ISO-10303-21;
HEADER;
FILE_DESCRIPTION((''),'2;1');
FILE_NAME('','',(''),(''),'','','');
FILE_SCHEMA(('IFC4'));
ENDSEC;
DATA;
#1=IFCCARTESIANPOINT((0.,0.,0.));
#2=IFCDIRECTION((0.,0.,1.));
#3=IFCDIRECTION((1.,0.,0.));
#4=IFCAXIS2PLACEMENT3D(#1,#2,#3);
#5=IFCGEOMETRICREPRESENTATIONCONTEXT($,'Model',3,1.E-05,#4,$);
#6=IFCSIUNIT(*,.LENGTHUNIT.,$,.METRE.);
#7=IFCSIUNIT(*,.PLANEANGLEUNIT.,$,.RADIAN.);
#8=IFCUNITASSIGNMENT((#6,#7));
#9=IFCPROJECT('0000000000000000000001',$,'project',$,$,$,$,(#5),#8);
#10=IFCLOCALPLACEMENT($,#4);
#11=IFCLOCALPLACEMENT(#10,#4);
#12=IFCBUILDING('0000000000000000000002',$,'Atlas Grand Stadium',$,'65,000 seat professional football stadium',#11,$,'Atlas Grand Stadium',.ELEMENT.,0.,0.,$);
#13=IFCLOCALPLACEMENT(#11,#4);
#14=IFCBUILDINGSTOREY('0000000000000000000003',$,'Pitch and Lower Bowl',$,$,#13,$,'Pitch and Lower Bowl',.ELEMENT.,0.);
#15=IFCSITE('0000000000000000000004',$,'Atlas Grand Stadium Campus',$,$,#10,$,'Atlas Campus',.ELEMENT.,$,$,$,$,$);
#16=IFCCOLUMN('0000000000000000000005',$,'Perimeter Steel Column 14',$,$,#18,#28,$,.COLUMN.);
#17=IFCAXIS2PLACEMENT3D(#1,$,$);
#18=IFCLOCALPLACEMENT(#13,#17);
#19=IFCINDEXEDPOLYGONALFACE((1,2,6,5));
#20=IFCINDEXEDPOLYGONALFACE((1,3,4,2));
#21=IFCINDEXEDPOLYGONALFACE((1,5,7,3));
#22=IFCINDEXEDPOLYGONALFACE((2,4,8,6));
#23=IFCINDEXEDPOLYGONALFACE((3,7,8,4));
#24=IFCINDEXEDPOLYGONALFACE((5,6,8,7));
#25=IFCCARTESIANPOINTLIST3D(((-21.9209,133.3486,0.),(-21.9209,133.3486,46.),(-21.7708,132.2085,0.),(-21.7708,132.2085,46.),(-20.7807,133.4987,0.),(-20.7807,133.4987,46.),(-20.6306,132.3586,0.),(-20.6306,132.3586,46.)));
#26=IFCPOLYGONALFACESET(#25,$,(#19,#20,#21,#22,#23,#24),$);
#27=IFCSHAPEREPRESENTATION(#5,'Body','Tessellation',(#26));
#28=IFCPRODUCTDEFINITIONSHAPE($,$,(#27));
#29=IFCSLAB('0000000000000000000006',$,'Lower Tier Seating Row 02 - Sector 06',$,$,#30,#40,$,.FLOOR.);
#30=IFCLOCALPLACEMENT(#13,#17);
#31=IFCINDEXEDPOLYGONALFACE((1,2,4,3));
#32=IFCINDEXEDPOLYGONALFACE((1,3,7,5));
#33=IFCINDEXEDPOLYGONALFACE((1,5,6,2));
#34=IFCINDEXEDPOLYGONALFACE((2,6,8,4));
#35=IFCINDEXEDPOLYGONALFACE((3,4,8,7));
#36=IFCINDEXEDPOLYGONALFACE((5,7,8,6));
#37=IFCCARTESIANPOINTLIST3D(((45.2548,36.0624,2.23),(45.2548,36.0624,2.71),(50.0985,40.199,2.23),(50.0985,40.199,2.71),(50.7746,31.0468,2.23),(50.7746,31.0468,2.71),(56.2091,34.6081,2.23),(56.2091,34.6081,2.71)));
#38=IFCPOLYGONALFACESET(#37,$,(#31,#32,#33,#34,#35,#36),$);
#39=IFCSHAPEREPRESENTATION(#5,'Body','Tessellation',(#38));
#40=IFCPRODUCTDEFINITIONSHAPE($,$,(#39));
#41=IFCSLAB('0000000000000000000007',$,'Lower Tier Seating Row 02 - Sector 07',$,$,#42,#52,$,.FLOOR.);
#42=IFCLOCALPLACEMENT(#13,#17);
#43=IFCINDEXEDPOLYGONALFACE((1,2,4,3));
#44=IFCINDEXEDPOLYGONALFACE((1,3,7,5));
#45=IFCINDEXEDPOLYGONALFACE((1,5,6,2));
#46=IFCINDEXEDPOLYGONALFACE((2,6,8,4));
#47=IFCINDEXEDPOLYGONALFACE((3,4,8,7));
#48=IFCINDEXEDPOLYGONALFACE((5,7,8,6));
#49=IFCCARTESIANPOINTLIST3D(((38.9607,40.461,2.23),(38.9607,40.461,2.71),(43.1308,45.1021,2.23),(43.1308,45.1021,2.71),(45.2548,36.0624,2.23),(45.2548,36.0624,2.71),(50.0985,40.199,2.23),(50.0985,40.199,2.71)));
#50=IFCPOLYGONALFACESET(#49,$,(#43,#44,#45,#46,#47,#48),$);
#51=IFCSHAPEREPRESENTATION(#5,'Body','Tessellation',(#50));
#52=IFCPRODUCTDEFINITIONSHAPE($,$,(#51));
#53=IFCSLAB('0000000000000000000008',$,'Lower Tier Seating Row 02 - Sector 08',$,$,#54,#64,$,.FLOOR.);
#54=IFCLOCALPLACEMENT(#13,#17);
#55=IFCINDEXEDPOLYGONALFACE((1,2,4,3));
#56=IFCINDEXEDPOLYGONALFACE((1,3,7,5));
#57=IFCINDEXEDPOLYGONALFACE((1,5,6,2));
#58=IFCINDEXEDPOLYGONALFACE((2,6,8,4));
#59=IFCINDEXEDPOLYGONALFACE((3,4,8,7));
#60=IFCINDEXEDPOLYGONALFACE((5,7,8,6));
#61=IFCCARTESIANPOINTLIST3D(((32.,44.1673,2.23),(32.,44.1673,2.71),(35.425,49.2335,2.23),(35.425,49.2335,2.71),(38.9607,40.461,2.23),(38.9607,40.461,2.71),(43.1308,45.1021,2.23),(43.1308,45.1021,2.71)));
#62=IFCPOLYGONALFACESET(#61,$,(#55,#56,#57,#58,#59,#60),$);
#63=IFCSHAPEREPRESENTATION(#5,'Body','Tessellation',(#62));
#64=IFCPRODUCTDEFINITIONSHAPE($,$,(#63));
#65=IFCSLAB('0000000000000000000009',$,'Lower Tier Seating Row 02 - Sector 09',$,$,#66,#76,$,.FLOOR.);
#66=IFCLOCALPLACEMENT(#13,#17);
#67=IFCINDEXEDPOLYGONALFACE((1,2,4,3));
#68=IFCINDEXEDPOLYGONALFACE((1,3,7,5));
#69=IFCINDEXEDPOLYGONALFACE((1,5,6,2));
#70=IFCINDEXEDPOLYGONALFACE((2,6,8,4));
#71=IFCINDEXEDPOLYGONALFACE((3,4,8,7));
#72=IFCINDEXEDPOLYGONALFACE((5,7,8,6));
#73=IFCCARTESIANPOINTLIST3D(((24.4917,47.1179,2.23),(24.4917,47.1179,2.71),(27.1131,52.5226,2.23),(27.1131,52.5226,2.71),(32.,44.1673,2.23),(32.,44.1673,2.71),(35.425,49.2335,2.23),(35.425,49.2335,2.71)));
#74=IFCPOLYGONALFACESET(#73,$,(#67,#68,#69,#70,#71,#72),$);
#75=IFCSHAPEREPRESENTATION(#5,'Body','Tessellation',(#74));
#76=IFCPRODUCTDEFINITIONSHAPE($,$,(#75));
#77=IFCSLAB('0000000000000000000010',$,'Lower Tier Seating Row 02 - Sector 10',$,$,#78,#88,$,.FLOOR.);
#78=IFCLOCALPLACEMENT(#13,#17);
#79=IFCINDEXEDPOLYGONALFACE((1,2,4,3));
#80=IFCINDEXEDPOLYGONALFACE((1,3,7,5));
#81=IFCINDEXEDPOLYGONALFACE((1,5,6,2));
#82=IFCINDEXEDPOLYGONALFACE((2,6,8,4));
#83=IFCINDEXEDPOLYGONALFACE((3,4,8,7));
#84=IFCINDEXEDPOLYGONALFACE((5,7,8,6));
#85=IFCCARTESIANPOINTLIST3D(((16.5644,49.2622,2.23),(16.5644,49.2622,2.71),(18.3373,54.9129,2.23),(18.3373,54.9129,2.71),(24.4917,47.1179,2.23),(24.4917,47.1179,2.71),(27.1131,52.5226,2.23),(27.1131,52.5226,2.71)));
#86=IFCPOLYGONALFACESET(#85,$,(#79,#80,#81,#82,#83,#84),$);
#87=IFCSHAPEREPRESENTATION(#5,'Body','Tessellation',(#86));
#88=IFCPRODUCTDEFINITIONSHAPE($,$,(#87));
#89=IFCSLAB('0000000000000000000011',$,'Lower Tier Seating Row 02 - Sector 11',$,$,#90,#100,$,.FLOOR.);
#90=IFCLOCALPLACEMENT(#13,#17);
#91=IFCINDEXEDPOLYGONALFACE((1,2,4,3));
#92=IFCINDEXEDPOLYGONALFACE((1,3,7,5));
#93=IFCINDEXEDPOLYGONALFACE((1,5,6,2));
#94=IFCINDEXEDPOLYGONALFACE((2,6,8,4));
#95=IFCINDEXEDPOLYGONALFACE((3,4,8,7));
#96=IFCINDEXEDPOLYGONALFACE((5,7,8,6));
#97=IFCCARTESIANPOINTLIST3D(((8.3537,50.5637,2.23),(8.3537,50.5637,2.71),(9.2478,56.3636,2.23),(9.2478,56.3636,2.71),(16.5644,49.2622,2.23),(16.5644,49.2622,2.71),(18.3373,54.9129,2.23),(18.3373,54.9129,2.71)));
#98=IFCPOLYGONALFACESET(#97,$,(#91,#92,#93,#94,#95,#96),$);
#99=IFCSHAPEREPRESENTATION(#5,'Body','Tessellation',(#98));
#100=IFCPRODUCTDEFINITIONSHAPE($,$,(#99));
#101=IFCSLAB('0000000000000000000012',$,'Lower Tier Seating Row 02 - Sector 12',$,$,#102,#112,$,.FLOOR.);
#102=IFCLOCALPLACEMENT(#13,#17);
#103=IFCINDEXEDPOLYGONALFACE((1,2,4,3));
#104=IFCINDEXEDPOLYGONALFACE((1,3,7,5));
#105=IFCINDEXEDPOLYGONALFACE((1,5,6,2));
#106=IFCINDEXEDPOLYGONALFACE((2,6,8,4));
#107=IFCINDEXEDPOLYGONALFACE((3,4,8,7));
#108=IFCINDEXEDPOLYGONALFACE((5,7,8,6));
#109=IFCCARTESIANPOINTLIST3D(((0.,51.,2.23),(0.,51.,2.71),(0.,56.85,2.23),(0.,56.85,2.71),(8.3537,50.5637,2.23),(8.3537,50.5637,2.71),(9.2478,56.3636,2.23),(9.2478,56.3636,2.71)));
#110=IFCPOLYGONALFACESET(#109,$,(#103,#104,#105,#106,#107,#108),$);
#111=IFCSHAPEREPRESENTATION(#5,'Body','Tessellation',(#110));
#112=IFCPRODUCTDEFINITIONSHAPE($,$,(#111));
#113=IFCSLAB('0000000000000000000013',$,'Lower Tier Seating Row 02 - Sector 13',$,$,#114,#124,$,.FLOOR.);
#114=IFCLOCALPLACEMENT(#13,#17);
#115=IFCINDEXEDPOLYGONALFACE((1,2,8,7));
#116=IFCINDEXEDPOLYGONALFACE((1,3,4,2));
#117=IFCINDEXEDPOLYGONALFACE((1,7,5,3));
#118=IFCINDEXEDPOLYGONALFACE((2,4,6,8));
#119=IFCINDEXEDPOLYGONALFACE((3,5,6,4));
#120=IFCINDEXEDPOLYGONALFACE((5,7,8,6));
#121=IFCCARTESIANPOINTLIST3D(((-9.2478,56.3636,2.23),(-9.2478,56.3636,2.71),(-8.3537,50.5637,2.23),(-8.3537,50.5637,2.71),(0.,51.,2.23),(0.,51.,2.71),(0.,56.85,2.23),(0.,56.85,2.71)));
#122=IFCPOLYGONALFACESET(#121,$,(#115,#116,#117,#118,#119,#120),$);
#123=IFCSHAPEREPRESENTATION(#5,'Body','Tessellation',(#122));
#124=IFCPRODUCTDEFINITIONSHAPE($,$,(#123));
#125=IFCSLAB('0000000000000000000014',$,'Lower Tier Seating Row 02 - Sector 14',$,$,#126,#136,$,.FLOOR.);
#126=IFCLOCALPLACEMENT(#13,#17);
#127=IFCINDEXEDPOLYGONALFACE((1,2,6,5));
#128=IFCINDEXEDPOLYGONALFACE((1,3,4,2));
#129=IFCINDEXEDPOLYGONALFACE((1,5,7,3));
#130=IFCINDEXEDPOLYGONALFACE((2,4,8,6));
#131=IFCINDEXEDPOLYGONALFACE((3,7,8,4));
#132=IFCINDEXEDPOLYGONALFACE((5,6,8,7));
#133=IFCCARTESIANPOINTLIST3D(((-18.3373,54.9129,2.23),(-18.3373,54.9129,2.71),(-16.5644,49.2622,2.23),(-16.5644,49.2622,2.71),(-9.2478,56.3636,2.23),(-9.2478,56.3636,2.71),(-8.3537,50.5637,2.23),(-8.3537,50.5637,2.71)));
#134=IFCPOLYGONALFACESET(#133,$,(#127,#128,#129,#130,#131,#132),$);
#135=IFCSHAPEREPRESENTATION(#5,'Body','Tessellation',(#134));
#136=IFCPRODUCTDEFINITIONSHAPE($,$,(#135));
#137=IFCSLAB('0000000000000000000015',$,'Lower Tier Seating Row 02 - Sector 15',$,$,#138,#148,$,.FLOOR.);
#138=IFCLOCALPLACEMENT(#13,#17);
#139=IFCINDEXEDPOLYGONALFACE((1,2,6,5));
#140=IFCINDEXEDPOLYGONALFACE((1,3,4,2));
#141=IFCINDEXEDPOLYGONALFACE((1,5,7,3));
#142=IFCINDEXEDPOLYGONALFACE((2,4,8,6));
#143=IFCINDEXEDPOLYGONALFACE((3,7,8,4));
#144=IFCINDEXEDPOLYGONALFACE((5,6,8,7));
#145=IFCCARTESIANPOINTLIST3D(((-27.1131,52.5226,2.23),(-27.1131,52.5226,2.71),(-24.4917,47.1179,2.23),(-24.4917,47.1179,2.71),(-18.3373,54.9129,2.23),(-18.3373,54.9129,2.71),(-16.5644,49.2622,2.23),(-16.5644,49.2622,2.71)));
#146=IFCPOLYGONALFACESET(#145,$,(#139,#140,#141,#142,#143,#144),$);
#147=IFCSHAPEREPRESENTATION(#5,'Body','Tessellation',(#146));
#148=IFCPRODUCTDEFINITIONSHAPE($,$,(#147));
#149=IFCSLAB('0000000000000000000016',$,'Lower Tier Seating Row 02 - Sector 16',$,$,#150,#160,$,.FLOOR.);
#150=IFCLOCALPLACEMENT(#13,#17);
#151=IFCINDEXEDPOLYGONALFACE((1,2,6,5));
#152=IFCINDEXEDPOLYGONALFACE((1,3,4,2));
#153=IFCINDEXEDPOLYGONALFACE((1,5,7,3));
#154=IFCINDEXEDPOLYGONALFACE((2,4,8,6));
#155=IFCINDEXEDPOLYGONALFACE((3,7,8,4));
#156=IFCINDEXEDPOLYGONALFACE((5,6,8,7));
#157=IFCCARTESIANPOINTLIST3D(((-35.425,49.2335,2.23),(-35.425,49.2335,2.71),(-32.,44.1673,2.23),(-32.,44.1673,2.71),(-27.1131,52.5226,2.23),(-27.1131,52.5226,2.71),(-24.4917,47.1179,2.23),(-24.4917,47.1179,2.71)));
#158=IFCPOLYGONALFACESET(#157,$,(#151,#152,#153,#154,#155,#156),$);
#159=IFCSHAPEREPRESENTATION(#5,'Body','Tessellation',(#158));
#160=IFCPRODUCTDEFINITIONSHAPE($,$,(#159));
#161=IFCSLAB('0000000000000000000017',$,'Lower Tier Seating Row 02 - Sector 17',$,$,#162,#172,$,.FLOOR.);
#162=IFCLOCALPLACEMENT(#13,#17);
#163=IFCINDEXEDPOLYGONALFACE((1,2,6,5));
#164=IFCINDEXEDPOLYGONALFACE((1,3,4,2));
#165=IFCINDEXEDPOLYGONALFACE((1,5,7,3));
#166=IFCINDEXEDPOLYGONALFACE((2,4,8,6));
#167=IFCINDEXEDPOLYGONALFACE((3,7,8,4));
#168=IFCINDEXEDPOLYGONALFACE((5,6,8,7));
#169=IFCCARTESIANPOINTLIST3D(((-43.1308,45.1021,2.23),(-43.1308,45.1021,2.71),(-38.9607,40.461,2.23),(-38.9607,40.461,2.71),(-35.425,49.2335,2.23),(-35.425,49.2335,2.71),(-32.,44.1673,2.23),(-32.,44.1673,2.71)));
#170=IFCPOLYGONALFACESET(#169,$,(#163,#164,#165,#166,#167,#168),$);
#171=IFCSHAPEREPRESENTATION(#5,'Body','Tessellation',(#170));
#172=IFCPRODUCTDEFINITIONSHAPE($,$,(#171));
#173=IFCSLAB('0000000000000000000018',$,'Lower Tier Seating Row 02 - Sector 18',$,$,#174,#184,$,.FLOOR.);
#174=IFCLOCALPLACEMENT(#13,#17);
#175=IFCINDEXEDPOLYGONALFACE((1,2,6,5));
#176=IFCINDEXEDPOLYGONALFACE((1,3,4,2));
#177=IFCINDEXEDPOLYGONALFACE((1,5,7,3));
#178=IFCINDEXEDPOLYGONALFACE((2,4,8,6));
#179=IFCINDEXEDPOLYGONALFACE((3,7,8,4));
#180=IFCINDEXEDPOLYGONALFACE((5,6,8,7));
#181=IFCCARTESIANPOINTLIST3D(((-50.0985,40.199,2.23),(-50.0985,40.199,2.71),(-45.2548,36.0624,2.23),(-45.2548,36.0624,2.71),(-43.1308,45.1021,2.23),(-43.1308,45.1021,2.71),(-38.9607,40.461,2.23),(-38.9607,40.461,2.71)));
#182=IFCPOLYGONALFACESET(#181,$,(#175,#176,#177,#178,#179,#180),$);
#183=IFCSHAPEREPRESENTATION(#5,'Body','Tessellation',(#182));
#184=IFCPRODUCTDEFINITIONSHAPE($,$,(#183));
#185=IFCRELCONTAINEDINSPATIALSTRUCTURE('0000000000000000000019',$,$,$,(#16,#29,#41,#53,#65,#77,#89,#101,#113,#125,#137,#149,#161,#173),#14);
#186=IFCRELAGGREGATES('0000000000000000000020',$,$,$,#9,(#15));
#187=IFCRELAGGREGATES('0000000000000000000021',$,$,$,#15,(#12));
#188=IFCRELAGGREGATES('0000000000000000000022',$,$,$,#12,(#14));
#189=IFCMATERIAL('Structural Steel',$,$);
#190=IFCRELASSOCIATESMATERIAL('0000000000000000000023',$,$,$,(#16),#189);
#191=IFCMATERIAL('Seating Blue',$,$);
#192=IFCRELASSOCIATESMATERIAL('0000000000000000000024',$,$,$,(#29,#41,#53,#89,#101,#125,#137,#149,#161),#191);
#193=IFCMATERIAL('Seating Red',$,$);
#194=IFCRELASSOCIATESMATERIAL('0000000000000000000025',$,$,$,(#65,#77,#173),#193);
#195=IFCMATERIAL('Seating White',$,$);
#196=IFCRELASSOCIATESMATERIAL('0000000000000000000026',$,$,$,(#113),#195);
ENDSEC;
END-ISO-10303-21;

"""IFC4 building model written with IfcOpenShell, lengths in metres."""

from ifc_helpers import new_model, si_unit, frame, origin_with_axes, origin_2d_with_axis, place, context, project, spatial, polyline, rectangle, outline, extrude, material, element, save


model = new_model("IFC4")

# Units and contexts
model_context = context("Model", 3, precision=1e-05, world=origin_with_axes())
ifc_project = project(units=[si_unit("LENGTHUNIT", "METRE"), si_unit("PLANEANGLEUNIT", "RADIAN")], contexts=[model_context])

# Site, building, storey
site_placement = place(None, origin_with_axes())
site = spatial("IfcSite", under=ifc_project, at=site_placement, Name="Atlas Grand Stadium Campus", LongName="Atlas Campus", CompositionType="ELEMENT")
building_placement = place(site_placement, origin_with_axes())
building = spatial("IfcBuilding", under=site, at=building_placement, Name="Atlas Grand Stadium", ObjectType="65,000 seat professional football stadium", LongName="Atlas Grand Stadium", CompositionType="ELEMENT", ElevationOfRefHeight=0.0, ElevationOfTerrain=0.0)
storey_placement = place(building_placement, origin_with_axes())
storey = spatial("IfcBuildingStorey", under=building, at=storey_placement, Name="Pitch and Lower Bowl", LongName="Pitch and Lower Bowl", CompositionType="ELEMENT", Elevation=0.0)

# Column
ifc_material_1 = material(Name="Structural Steel")
column_placement = place(storey_placement, frame((-21.2758, 132.8536, 0.0), z_axis=(0.0, 0.0, 1.0), x_axis=(-0.99144, -0.13053, 0.0)))
element("IfcColumn", 1, at=column_placement, inside=storey, material=ifc_material_1, Name="Perimeter Steel Column 14", PredefinedType="COLUMN", context=model_context, shape_type="SweptSolid", body=[
    extrude(rectangle(XDim=1.15, YDim=1.15, at=origin_2d_with_axis()), origin_with_axes(), (0.0, 0.0, 1.0), 46.0),
])

# Slabs
ifc_material_2 = material(Name="Seating Blue")
slab_1_placement = place(storey_placement, frame((0.0, 0.0, 2.23), z_axis=(0.0, 0.0, 1.0), x_axis=(1.0, 0.0, 0.0)))
element("IfcSlab", 2, at=slab_1_placement, inside=storey, material=ifc_material_2, Name="Lower Tier Seating Row 02 - Sector 06", PredefinedType="FLOOR", context=model_context, shape_type="SweptSolid", body=[
    extrude(outline(polyline([(56.2091, 34.6081), (50.0985, 40.199), (45.2548, 36.0624), (50.7746, 31.0468), (56.2091, 34.6081)])), origin_with_axes(), (0.0, 0.0, 1.0), 0.48),
])
slab_2_placement = place(storey_placement, frame((0.0, 0.0, 2.23), z_axis=(0.0, 0.0, 1.0), x_axis=(1.0, 0.0, 0.0)))
element("IfcSlab", 3, at=slab_2_placement, inside=storey, material=ifc_material_2, Name="Lower Tier Seating Row 02 - Sector 07", PredefinedType="FLOOR", context=model_context, shape_type="SweptSolid", body=[
    extrude(outline(polyline([(50.0985, 40.199), (43.1307, 45.1021), (38.9607, 40.461), (45.2548, 36.0624), (50.0985, 40.199)])), origin_with_axes(), (0.0, 0.0, 1.0), 0.48),
])
slab_3_placement = place(storey_placement, frame((0.0, 0.0, 2.23), z_axis=(0.0, 0.0, 1.0), x_axis=(1.0, 0.0, 0.0)))
element("IfcSlab", 4, at=slab_3_placement, inside=storey, material=ifc_material_2, Name="Lower Tier Seating Row 02 - Sector 08", PredefinedType="FLOOR", context=model_context, shape_type="SweptSolid", body=[
    extrude(outline(polyline([(43.1307, 45.1021), (35.425, 49.2335), (32.0, 44.1673), (38.9607, 40.461), (43.1307, 45.1021)])), origin_with_axes(), (0.0, 0.0, 1.0), 0.48),
])
ifc_material_3 = material(Name="Seating Red")
slab_4_placement = place(storey_placement, frame((0.0, 0.0, 2.23), z_axis=(0.0, 0.0, 1.0), x_axis=(1.0, 0.0, 0.0)))
element("IfcSlab", 5, at=slab_4_placement, inside=storey, material=ifc_material_3, Name="Lower Tier Seating Row 02 - Sector 09", PredefinedType="FLOOR", context=model_context, shape_type="SweptSolid", body=[
    extrude(outline(polyline([(35.425, 49.2335), (27.1131, 52.5226), (24.4917, 47.1179), (32.0, 44.1673), (35.425, 49.2335)])), origin_with_axes(), (0.0, 0.0, 1.0), 0.48),
])
slab_5_placement = place(storey_placement, frame((0.0, 0.0, 2.23), z_axis=(0.0, 0.0, 1.0), x_axis=(1.0, 0.0, 0.0)))
element("IfcSlab", 6, at=slab_5_placement, inside=storey, material=ifc_material_3, Name="Lower Tier Seating Row 02 - Sector 10", PredefinedType="FLOOR", context=model_context, shape_type="SweptSolid", body=[
    extrude(outline(polyline([(27.1131, 52.5226), (18.3373, 54.9129), (16.5644, 49.2622), (24.4917, 47.1179), (27.1131, 52.5226)])), origin_with_axes(), (0.0, 0.0, 1.0), 0.48),
])
slab_6_placement = place(storey_placement, frame((0.0, 0.0, 2.23), z_axis=(0.0, 0.0, 1.0), x_axis=(1.0, 0.0, 0.0)))
element("IfcSlab", 7, at=slab_6_placement, inside=storey, material=ifc_material_2, Name="Lower Tier Seating Row 02 - Sector 11", PredefinedType="FLOOR", context=model_context, shape_type="SweptSolid", body=[
    extrude(outline(polyline([(18.3373, 54.9129), (9.2478, 56.3636), (8.3537, 50.5637), (16.5644, 49.2622), (18.3373, 54.9129)])), origin_with_axes(), (0.0, 0.0, 1.0), 0.48),
])
slab_7_placement = place(storey_placement, frame((0.0, 0.0, 2.23), z_axis=(0.0, 0.0, 1.0), x_axis=(1.0, 0.0, 0.0)))
element("IfcSlab", 8, at=slab_7_placement, inside=storey, material=ifc_material_2, Name="Lower Tier Seating Row 02 - Sector 12", PredefinedType="FLOOR", context=model_context, shape_type="SweptSolid", body=[
    extrude(outline(polyline([(9.2478, 56.3636), (0.0, 56.85), (0.0, 51.0), (8.3537, 50.5637), (9.2478, 56.3636)])), origin_with_axes(), (0.0, 0.0, 1.0), 0.48),
])
ifc_material_4 = material(Name="Seating White")
slab_8_placement = place(storey_placement, frame((0.0, 0.0, 2.23), z_axis=(0.0, 0.0, 1.0), x_axis=(1.0, 0.0, 0.0)))
element("IfcSlab", 9, at=slab_8_placement, inside=storey, material=ifc_material_4, Name="Lower Tier Seating Row 02 - Sector 13", PredefinedType="FLOOR", context=model_context, shape_type="SweptSolid", body=[
    extrude(outline(polyline([(0.0, 56.85), (-9.2478, 56.3636), (-8.3537, 50.5637), (0.0, 51.0), (0.0, 56.85)])), origin_with_axes(), (0.0, 0.0, 1.0), 0.48),
])
slab_9_placement = place(storey_placement, frame((0.0, 0.0, 2.23), z_axis=(0.0, 0.0, 1.0), x_axis=(1.0, 0.0, 0.0)))
element("IfcSlab", 10, at=slab_9_placement, inside=storey, material=ifc_material_2, Name="Lower Tier Seating Row 02 - Sector 14", PredefinedType="FLOOR", context=model_context, shape_type="SweptSolid", body=[
    extrude(outline(polyline([(-9.2478, 56.3636), (-18.3373, 54.9129), (-16.5644, 49.2622), (-8.3537, 50.5637), (-9.2478, 56.3636)])), origin_with_axes(), (0.0, 0.0, 1.0), 0.48),
])
slab_10_placement = place(storey_placement, frame((0.0, 0.0, 2.23), z_axis=(0.0, 0.0, 1.0), x_axis=(1.0, 0.0, 0.0)))
element("IfcSlab", 11, at=slab_10_placement, inside=storey, material=ifc_material_2, Name="Lower Tier Seating Row 02 - Sector 15", PredefinedType="FLOOR", context=model_context, shape_type="SweptSolid", body=[
    extrude(outline(polyline([(-18.3373, 54.9129), (-27.1131, 52.5226), (-24.4917, 47.1179), (-16.5644, 49.2622), (-18.3373, 54.9129)])), origin_with_axes(), (0.0, 0.0, 1.0), 0.48),
])
slab_11_placement = place(storey_placement, frame((0.0, 0.0, 2.23), z_axis=(0.0, 0.0, 1.0), x_axis=(1.0, 0.0, 0.0)))
element("IfcSlab", 12, at=slab_11_placement, inside=storey, material=ifc_material_2, Name="Lower Tier Seating Row 02 - Sector 16", PredefinedType="FLOOR", context=model_context, shape_type="SweptSolid", body=[
    extrude(outline(polyline([(-27.1131, 52.5226), (-35.425, 49.2335), (-32.0, 44.1673), (-24.4917, 47.1179), (-27.1131, 52.5226)])), origin_with_axes(), (0.0, 0.0, 1.0), 0.48),
])
slab_12_placement = place(storey_placement, frame((0.0, 0.0, 2.23), z_axis=(0.0, 0.0, 1.0), x_axis=(1.0, 0.0, 0.0)))
element("IfcSlab", 13, at=slab_12_placement, inside=storey, material=ifc_material_2, Name="Lower Tier Seating Row 02 - Sector 17", PredefinedType="FLOOR", context=model_context, shape_type="SweptSolid", body=[
    extrude(outline(polyline([(-35.425, 49.2335), (-43.1307, 45.1021), (-38.9607, 40.461), (-32.0, 44.1673), (-35.425, 49.2335)])), origin_with_axes(), (0.0, 0.0, 1.0), 0.48),
])
slab_13_placement = place(storey_placement, frame((0.0, 0.0, 2.23), z_axis=(0.0, 0.0, 1.0), x_axis=(1.0, 0.0, 0.0)))
element("IfcSlab", 14, at=slab_13_placement, inside=storey, material=ifc_material_3, Name="Lower Tier Seating Row 02 - Sector 18", PredefinedType="FLOOR", context=model_context, shape_type="SweptSolid", body=[
    extrude(outline(polyline([(-43.1307, 45.1021), (-50.0985, 40.199), (-45.2548, 36.0624), (-38.9607, 40.461), (-43.1307, 45.1021)])), origin_with_axes(), (0.0, 0.0, 1.0), 0.48),
])

save(model, "model.ifc")
